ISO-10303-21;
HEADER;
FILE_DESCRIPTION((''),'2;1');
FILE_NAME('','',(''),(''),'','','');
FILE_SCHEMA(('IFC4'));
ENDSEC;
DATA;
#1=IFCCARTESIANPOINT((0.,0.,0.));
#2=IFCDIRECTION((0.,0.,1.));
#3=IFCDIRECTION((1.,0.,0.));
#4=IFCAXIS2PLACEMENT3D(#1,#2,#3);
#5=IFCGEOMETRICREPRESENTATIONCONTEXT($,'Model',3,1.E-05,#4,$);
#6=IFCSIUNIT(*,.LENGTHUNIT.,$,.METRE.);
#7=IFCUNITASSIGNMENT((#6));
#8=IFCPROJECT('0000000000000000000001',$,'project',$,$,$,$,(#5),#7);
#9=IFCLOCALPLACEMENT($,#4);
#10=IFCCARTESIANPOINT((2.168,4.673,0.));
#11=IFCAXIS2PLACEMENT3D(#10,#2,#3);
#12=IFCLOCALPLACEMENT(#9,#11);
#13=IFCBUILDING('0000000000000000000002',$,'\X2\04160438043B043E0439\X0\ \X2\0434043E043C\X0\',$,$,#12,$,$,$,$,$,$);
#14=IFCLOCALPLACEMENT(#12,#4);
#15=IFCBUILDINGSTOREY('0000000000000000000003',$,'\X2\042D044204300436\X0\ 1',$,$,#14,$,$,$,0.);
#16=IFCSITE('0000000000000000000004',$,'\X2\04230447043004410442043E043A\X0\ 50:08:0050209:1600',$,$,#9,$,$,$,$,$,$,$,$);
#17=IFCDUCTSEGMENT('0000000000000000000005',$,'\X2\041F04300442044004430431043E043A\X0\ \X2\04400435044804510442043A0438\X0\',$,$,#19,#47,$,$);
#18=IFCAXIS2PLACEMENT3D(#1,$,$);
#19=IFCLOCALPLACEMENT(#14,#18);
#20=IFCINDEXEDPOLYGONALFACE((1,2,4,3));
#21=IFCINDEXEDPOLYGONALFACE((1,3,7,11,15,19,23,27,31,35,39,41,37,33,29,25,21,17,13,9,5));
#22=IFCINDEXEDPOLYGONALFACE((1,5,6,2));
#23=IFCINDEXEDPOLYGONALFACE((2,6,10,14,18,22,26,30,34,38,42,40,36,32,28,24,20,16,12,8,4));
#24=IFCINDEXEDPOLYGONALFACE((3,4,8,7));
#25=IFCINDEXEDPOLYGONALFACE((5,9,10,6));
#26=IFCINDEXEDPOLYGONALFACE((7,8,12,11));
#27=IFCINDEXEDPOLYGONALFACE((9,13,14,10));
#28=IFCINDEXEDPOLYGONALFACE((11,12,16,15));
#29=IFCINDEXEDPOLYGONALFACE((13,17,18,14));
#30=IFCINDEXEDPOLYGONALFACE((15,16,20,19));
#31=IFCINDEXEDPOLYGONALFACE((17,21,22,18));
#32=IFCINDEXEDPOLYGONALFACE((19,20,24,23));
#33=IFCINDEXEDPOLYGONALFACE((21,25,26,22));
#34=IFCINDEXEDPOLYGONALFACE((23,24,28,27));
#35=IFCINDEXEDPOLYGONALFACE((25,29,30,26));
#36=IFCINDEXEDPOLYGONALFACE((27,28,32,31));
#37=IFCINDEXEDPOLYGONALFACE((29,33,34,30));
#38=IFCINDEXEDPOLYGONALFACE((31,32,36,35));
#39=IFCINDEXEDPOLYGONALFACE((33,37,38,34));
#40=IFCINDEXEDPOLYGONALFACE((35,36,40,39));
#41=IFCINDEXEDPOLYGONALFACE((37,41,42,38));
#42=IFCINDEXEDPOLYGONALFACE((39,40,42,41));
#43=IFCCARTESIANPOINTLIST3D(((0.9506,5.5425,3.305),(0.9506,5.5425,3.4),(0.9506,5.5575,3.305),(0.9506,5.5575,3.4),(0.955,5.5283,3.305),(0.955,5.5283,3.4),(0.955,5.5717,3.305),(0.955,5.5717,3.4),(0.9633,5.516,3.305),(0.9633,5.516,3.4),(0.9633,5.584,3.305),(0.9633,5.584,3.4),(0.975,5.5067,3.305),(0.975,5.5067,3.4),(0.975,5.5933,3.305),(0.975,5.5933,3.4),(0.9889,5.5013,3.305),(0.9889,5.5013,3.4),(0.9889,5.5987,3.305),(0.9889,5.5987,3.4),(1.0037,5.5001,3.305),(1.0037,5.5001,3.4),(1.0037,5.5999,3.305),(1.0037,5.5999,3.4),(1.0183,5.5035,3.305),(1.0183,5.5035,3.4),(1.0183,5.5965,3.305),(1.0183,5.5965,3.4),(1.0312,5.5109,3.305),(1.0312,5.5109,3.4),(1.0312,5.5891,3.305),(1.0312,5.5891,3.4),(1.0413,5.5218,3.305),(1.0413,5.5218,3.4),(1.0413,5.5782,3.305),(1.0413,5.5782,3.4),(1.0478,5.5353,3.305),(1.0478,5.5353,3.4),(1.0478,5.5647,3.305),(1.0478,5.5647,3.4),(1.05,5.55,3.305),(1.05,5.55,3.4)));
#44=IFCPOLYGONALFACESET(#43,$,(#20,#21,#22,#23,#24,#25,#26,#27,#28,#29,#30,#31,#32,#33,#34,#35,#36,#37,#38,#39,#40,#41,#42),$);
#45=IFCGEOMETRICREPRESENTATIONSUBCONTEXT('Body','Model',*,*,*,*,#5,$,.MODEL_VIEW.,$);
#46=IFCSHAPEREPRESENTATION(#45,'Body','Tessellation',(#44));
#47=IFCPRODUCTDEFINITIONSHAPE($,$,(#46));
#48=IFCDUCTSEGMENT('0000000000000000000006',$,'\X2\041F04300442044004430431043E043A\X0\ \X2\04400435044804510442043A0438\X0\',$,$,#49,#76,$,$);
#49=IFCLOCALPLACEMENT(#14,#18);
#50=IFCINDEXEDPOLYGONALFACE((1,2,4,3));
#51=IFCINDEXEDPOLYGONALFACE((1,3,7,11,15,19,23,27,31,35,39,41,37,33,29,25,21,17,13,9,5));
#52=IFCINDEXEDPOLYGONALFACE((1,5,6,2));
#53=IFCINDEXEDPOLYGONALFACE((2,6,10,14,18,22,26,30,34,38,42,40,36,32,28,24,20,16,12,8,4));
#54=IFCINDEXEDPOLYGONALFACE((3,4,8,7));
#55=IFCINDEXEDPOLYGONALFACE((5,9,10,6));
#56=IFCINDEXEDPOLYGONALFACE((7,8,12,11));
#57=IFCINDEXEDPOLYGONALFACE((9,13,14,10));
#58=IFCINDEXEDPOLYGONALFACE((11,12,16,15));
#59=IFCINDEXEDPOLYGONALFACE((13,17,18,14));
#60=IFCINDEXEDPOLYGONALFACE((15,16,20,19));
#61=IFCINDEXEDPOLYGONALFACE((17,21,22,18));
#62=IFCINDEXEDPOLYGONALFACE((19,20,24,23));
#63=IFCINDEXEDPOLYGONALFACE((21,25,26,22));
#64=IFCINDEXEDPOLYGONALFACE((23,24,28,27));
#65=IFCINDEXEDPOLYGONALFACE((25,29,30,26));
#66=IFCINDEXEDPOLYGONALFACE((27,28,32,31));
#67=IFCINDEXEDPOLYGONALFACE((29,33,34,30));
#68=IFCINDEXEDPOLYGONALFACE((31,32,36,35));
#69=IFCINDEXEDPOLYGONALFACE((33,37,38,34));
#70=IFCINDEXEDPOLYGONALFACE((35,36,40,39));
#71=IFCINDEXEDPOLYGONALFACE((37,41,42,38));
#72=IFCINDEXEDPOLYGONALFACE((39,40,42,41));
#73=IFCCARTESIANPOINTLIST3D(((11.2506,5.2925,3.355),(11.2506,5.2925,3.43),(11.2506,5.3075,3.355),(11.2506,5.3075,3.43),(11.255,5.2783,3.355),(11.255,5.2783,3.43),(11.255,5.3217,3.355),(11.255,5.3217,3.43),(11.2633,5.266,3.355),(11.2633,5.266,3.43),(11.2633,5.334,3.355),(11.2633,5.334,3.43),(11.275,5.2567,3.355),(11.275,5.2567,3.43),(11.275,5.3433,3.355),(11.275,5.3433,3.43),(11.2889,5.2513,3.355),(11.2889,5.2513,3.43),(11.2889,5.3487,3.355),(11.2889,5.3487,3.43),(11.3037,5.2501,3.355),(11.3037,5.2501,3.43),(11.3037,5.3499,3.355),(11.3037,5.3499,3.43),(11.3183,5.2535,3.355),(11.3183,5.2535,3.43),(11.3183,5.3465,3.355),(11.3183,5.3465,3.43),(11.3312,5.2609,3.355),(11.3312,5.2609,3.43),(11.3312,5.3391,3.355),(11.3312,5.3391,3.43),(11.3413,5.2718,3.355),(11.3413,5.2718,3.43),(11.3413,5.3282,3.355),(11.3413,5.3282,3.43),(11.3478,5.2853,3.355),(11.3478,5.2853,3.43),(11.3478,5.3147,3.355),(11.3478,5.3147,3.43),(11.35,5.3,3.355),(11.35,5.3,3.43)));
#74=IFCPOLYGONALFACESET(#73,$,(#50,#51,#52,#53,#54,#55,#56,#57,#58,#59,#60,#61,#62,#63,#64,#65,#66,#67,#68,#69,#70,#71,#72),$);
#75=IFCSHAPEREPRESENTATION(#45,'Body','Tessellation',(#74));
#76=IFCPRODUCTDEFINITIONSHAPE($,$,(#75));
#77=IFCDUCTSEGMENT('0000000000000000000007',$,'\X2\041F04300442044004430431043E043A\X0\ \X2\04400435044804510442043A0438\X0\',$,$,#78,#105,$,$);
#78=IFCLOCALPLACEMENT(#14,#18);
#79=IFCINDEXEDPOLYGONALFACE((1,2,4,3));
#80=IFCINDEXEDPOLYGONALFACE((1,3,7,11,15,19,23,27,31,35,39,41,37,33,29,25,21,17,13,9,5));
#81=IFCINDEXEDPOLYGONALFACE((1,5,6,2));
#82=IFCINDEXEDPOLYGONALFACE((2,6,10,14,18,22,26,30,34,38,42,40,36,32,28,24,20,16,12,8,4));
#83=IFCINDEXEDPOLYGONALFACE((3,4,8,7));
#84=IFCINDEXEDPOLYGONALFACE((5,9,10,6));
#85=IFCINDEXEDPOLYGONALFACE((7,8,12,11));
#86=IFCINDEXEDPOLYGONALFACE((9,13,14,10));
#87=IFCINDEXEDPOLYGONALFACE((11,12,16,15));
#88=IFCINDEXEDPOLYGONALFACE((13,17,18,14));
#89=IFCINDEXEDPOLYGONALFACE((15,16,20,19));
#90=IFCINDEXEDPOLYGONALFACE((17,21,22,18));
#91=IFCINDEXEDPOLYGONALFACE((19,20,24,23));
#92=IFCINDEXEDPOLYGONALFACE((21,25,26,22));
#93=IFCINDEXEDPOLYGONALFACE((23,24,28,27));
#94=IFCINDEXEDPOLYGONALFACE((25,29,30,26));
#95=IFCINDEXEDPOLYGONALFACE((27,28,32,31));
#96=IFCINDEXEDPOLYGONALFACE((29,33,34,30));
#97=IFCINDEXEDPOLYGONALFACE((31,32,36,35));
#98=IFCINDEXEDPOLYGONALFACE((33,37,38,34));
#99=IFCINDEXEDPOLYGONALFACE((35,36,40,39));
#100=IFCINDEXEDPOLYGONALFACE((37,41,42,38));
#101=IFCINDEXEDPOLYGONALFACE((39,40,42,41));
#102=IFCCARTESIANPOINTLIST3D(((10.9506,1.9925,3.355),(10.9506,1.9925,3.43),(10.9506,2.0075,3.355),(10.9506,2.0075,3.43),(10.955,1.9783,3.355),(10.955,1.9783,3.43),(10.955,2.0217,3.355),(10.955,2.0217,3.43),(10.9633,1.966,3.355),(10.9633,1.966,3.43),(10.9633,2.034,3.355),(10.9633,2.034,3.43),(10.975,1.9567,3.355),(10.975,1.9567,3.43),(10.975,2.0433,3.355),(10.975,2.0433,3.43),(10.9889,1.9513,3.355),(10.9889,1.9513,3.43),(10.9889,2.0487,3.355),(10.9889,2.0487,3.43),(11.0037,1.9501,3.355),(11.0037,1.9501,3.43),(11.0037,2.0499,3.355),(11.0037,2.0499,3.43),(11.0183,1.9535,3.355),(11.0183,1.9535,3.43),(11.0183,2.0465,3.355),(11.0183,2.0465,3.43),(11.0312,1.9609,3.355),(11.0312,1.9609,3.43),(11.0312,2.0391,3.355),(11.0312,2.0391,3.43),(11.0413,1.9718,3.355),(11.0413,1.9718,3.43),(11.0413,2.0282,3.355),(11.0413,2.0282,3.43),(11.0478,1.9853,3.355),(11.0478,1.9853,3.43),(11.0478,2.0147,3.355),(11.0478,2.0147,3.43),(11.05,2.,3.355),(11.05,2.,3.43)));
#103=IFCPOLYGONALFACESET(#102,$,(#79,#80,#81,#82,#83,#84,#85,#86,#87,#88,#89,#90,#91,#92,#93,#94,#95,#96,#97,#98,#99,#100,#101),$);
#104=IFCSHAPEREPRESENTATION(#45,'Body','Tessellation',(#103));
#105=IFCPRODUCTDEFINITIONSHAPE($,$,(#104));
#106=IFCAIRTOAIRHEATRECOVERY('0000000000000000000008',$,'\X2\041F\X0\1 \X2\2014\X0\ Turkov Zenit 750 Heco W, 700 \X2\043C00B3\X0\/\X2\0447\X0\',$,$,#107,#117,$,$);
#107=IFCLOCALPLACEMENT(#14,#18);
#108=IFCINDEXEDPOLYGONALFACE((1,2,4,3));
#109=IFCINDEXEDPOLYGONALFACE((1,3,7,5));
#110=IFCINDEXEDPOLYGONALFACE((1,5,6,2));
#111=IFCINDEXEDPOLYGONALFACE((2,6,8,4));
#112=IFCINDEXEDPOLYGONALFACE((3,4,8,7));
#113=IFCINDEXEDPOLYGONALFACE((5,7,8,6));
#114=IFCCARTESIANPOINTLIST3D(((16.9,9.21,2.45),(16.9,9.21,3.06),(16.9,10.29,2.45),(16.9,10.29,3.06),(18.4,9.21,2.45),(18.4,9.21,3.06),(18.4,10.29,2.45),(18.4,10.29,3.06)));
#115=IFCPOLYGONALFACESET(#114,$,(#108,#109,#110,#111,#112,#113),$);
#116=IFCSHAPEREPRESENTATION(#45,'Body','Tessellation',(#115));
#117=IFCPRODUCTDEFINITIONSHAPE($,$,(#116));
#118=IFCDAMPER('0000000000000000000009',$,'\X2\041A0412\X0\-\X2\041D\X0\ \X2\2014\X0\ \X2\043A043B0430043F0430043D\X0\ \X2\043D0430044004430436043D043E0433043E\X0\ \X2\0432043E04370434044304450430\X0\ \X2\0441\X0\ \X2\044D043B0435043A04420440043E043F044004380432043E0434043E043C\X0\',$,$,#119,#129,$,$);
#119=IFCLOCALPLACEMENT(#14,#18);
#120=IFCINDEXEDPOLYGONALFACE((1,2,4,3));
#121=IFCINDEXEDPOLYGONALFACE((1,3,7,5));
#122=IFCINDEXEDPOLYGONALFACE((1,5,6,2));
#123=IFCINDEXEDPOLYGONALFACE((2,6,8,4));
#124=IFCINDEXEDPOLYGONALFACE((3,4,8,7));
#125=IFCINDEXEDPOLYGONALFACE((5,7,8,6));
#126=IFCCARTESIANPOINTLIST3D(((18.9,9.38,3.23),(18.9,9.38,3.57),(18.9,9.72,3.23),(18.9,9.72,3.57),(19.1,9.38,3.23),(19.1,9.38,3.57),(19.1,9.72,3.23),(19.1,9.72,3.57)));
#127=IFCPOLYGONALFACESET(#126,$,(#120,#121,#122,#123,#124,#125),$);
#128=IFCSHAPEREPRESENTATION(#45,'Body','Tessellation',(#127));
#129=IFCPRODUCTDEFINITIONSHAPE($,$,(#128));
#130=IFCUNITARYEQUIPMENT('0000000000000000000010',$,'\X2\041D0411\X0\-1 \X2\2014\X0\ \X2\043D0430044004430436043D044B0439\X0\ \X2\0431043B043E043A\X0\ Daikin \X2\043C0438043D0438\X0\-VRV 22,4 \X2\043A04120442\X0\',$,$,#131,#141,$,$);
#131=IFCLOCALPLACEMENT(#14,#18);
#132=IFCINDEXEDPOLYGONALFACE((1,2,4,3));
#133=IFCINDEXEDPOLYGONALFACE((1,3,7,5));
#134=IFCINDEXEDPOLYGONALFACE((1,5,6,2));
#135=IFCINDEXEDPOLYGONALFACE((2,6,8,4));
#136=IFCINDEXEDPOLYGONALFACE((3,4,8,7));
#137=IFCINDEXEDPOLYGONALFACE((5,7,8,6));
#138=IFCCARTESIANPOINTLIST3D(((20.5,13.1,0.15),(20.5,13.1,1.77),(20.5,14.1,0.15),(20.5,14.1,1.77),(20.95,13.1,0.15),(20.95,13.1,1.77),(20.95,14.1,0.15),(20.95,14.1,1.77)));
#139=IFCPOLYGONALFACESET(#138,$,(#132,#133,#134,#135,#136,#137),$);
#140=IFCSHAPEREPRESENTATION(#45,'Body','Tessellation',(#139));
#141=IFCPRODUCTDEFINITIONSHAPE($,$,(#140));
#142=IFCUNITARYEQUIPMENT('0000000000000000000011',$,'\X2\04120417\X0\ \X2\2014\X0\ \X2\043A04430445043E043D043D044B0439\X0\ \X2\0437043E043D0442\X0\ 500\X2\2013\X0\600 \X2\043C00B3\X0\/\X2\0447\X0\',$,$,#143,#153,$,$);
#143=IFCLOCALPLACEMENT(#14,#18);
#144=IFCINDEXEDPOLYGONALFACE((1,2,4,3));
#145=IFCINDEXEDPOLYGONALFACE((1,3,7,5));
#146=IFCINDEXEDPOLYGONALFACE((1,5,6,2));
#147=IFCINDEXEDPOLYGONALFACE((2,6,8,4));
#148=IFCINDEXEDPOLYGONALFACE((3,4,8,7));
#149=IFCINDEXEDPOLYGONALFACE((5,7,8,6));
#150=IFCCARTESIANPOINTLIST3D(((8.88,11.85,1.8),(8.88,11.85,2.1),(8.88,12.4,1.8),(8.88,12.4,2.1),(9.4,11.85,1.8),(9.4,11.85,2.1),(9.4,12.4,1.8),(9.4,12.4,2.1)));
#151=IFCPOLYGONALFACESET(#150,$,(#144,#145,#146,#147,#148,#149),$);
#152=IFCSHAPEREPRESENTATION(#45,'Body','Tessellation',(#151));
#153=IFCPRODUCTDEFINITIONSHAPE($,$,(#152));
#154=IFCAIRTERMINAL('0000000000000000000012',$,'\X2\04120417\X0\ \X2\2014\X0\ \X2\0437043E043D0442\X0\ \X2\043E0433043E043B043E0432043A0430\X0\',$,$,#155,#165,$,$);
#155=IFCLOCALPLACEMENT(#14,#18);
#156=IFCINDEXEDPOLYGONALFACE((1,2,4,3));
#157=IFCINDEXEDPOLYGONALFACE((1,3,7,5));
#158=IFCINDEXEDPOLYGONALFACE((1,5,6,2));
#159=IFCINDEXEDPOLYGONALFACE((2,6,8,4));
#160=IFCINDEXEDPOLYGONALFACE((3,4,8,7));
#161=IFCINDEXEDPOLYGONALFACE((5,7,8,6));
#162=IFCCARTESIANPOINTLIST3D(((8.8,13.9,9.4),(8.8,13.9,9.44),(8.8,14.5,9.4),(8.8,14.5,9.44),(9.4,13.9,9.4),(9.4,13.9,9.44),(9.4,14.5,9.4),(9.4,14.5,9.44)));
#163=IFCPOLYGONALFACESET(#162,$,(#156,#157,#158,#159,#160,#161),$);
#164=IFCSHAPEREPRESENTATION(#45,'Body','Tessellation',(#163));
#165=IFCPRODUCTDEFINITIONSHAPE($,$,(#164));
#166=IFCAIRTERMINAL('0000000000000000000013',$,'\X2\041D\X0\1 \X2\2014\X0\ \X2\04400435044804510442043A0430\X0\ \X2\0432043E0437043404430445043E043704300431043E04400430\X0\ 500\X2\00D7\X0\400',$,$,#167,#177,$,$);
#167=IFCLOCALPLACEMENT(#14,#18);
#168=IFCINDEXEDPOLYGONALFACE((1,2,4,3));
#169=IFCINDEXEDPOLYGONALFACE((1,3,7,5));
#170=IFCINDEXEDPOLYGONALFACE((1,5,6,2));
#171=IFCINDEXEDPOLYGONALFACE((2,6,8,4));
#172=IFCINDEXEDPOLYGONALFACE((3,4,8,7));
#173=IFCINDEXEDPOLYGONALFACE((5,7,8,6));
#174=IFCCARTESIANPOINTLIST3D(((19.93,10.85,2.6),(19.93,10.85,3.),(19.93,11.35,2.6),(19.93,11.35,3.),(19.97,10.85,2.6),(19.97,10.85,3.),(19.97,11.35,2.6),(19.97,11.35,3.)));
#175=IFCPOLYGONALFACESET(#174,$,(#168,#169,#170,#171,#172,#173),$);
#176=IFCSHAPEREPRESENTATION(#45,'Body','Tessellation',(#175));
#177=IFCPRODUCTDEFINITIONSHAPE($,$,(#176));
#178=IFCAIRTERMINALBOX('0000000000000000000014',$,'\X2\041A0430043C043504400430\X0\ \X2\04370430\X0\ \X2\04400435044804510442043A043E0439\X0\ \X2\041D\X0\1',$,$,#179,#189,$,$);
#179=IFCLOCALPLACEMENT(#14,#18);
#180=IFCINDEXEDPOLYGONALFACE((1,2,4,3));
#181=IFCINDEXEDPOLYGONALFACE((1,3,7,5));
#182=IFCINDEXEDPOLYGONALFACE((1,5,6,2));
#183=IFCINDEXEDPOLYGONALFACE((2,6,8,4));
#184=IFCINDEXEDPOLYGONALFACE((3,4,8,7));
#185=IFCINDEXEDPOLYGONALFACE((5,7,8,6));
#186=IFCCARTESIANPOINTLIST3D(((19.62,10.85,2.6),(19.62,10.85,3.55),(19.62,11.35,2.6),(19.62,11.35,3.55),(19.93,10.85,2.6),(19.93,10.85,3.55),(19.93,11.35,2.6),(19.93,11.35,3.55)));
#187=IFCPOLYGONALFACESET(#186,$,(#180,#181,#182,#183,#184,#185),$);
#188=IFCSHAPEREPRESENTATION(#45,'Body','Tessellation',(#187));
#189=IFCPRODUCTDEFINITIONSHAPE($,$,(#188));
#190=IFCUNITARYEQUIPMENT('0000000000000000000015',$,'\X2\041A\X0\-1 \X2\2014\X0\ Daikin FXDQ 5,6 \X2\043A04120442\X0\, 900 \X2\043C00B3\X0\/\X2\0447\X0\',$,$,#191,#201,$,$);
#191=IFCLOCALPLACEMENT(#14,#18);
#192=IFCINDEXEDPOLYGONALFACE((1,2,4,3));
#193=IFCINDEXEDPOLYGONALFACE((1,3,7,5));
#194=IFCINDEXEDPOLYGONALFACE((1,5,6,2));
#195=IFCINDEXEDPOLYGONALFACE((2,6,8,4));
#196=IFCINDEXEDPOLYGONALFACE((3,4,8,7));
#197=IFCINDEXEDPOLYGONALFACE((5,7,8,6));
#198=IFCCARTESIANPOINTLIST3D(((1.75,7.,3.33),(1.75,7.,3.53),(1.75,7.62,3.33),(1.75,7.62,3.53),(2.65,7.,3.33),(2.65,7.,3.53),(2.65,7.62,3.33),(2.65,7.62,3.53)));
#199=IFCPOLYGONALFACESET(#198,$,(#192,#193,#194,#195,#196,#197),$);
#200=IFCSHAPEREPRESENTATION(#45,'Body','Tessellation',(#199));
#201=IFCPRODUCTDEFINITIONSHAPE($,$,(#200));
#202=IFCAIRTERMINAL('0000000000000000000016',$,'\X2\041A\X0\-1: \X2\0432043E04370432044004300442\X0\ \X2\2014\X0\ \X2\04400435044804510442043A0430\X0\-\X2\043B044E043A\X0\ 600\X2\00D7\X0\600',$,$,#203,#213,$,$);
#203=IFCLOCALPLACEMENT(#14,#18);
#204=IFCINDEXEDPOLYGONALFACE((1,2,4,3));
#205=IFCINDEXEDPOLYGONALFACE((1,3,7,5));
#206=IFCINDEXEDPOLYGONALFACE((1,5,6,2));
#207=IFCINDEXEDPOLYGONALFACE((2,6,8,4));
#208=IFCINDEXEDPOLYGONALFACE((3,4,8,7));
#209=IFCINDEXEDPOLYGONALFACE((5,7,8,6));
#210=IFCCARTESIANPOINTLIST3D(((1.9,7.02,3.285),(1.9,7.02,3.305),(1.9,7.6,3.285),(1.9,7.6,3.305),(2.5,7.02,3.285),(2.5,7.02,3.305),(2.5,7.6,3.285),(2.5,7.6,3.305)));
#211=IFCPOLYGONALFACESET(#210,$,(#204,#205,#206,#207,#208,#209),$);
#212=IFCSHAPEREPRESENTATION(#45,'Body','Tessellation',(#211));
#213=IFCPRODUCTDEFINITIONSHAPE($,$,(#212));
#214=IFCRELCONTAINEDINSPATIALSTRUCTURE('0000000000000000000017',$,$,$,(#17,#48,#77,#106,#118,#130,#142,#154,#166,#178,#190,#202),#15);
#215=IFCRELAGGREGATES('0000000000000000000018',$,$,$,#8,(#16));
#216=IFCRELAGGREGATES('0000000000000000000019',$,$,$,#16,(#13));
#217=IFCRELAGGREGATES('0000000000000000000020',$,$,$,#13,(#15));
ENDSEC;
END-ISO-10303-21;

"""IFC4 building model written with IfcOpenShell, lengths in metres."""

from ifc_helpers import new_model, si_unit, frame, frame_2d, origin_with_axes, origin_2d, place, context, subcontext, project, spatial, rectangle, circle, extrude, element, save


model = new_model("IFC4")

# Units and contexts
model_context = context("Model", 3, precision=1e-05, world=origin_with_axes())
body_context = subcontext(model_context, "Body", "Model", "MODEL_VIEW")
ifc_project = project(units=[si_unit("LENGTHUNIT", "METRE")], contexts=[model_context])

# Site, building, storey
site_placement = place(None, origin_with_axes())
site = spatial("IfcSite", under=ifc_project, at=site_placement, Name="Участок 50:08:0050209:1600")
building_placement = place(site_placement, frame((2.168, 4.673, 0.0), z_axis=(0.0, 0.0, 1.0), x_axis=(1.0, 0.0, 0.0)))
building = spatial("IfcBuilding", under=site, at=building_placement, Name="Жилой дом")
storey_placement = place(building_placement, origin_with_axes())
storey = spatial("IfcBuildingStorey", under=building, at=storey_placement, Name="Этаж 1", Elevation=0.0)

# Duct segments
duct_segment_1_placement = place(storey_placement, origin_with_axes())
element("IfcDuctSegment", 1, at=duct_segment_1_placement, inside=storey, Name="Патрубок решётки", context=body_context, shape_type="SweptSolid", body=[
    extrude(circle(Radius=0.05, at=origin_2d()), frame((1.0, 5.55, 3.4), z_axis=(0.0, 0.0, -1.0), x_axis=(1.0, 0.0, 0.0)), (0.0, 0.0, 1.0), 0.095),
])
duct_segment_2_placement = place(storey_placement, origin_with_axes())
element("IfcDuctSegment", 2, at=duct_segment_2_placement, inside=storey, Name="Патрубок решётки", context=body_context, shape_type="SweptSolid", body=[
    extrude(circle(Radius=0.05, at=origin_2d()), frame((11.3, 5.3, 3.43), z_axis=(0.0, 0.0, -1.0), x_axis=(1.0, 0.0, 0.0)), (0.0, 0.0, 1.0), 0.075),
])
duct_segment_3_placement = place(storey_placement, origin_with_axes())
element("IfcDuctSegment", 3, at=duct_segment_3_placement, inside=storey, Name="Патрубок решётки", context=body_context, shape_type="SweptSolid", body=[
    extrude(circle(Radius=0.05, at=origin_2d()), frame((11.0, 2.0, 3.43), z_axis=(0.0, 0.0, -1.0), x_axis=(1.0, 0.0, 0.0)), (0.0, 0.0, 1.0), 0.075),
])

# Air to air heat recovery
air_to_air_heat_recovery_placement = place(storey_placement, origin_with_axes())
element("IfcAirToAirHeatRecovery", 4, at=air_to_air_heat_recovery_placement, inside=storey, Name="П1 — Turkov Zenit 750 Heco W, 700 м³/ч", context=body_context, shape_type="SweptSolid", body=[
    extrude(rectangle(XDim=1.5, YDim=1.08, at=frame_2d((0.75, 0.54))), frame((16.9, 9.21, 2.45), z_axis=(0.0, 0.0, 1.0), x_axis=(1.0, 0.0, 0.0)), (0.0, 0.0, 1.0), 0.61),
])

# Damper
damper_placement = place(storey_placement, origin_with_axes())
element("IfcDamper", 5, at=damper_placement, inside=storey, Name="КВ-Н — клапан наружного воздуха с электроприводом", context=body_context, shape_type="SweptSolid", body=[
    extrude(rectangle(XDim=0.2, YDim=0.34, at=frame_2d((0.1, 0.17))), frame((18.9, 9.38, 3.23), z_axis=(0.0, 0.0, 1.0), x_axis=(1.0, 0.0, 0.0)), (0.0, 0.0, 1.0), 0.34),
])

# Unitary equipment
unitary_equipment_1_placement = place(storey_placement, origin_with_axes())
element("IfcUnitaryEquipment", 6, at=unitary_equipment_1_placement, inside=storey, Name="НБ-1 — наружный блок Daikin мини-VRV 22,4 кВт", context=body_context, shape_type="SweptSolid", body=[
    extrude(rectangle(XDim=0.45, YDim=1.0, at=frame_2d((0.225, 0.5))), frame((20.5, 13.1, 0.15), z_axis=(0.0, 0.0, 1.0), x_axis=(1.0, 0.0, 0.0)), (0.0, 0.0, 1.0), 1.62),
])
unitary_equipment_2_placement = place(storey_placement, origin_with_axes())
element("IfcUnitaryEquipment", 7, at=unitary_equipment_2_placement, inside=storey, Name="ВЗ — кухонный зонт 500–600 м³/ч", context=body_context, shape_type="SweptSolid", body=[
    extrude(rectangle(XDim=0.52, YDim=0.55, at=frame_2d((0.26, 0.275))), frame((8.88, 11.85, 1.8), z_axis=(0.0, 0.0, 1.0), x_axis=(1.0, 0.0, 0.0)), (0.0, 0.0, 1.0), 0.3),
])

# Air terminals
air_terminal_1_placement = place(storey_placement, origin_with_axes())
element("IfcAirTerminal", 8, at=air_terminal_1_placement, inside=storey, Name="ВЗ — зонт оголовка", context=body_context, shape_type="SweptSolid", body=[
    extrude(rectangle(XDim=0.6, YDim=0.6, at=frame_2d((0.3, 0.3))), frame((8.8, 13.9, 9.4), z_axis=(0.0, 0.0, 1.0), x_axis=(1.0, 0.0, 0.0)), (0.0, 0.0, 1.0), 0.04),
])
air_terminal_2_placement = place(storey_placement, origin_with_axes())
element("IfcAirTerminal", 9, at=air_terminal_2_placement, inside=storey, Name="Н1 — решётка воздухозабора 500×400", context=body_context, shape_type="SweptSolid", body=[
    extrude(rectangle(XDim=0.04, YDim=0.5, at=frame_2d((0.02, 0.25))), frame((19.93, 10.85, 2.6), z_axis=(0.0, 0.0, 1.0), x_axis=(1.0, 0.0, 0.0)), (0.0, 0.0, 1.0), 0.4),
])

# Air terminal box
air_terminal_box_1_placement = place(storey_placement, origin_with_axes())
element("IfcAirTerminalBox", 10, at=air_terminal_box_1_placement, inside=storey, Name="Камера за решёткой Н1", context=body_context, shape_type="SweptSolid", body=[
    extrude(rectangle(XDim=0.31, YDim=0.5, at=frame_2d((0.155, 0.25))), frame((19.62, 10.85, 2.6), z_axis=(0.0, 0.0, 1.0), x_axis=(1.0, 0.0, 0.0)), (0.0, 0.0, 1.0), 0.95),
])

# Unitary equipment
unitary_equipment_3_placement = place(storey_placement, origin_with_axes())
element("IfcUnitaryEquipment", 11, at=unitary_equipment_3_placement, inside=storey, Name="К-1 — Daikin FXDQ 5,6 кВт, 900 м³/ч", context=body_context, shape_type="SweptSolid", body=[
    extrude(rectangle(XDim=0.9, YDim=0.62, at=frame_2d((0.45, 0.31))), frame((1.75, 7.0, 3.33), z_axis=(0.0, 0.0, 1.0), x_axis=(1.0, 0.0, 0.0)), (0.0, 0.0, 1.0), 0.2),
])

# Air terminal
air_terminal_3_placement = place(storey_placement, origin_with_axes())
element("IfcAirTerminal", 12, at=air_terminal_3_placement, inside=storey, Name="К-1: возврат — решётка-люк 600×600", context=body_context, shape_type="SweptSolid", body=[
    extrude(rectangle(XDim=0.6, YDim=0.58, at=frame_2d((0.3, 0.29))), frame((1.9, 7.02, 3.285), z_axis=(0.0, 0.0, 1.0), x_axis=(1.0, 0.0, 0.0)), (0.0, 0.0, 1.0), 0.02),
])

save(model, "model.ifc")
